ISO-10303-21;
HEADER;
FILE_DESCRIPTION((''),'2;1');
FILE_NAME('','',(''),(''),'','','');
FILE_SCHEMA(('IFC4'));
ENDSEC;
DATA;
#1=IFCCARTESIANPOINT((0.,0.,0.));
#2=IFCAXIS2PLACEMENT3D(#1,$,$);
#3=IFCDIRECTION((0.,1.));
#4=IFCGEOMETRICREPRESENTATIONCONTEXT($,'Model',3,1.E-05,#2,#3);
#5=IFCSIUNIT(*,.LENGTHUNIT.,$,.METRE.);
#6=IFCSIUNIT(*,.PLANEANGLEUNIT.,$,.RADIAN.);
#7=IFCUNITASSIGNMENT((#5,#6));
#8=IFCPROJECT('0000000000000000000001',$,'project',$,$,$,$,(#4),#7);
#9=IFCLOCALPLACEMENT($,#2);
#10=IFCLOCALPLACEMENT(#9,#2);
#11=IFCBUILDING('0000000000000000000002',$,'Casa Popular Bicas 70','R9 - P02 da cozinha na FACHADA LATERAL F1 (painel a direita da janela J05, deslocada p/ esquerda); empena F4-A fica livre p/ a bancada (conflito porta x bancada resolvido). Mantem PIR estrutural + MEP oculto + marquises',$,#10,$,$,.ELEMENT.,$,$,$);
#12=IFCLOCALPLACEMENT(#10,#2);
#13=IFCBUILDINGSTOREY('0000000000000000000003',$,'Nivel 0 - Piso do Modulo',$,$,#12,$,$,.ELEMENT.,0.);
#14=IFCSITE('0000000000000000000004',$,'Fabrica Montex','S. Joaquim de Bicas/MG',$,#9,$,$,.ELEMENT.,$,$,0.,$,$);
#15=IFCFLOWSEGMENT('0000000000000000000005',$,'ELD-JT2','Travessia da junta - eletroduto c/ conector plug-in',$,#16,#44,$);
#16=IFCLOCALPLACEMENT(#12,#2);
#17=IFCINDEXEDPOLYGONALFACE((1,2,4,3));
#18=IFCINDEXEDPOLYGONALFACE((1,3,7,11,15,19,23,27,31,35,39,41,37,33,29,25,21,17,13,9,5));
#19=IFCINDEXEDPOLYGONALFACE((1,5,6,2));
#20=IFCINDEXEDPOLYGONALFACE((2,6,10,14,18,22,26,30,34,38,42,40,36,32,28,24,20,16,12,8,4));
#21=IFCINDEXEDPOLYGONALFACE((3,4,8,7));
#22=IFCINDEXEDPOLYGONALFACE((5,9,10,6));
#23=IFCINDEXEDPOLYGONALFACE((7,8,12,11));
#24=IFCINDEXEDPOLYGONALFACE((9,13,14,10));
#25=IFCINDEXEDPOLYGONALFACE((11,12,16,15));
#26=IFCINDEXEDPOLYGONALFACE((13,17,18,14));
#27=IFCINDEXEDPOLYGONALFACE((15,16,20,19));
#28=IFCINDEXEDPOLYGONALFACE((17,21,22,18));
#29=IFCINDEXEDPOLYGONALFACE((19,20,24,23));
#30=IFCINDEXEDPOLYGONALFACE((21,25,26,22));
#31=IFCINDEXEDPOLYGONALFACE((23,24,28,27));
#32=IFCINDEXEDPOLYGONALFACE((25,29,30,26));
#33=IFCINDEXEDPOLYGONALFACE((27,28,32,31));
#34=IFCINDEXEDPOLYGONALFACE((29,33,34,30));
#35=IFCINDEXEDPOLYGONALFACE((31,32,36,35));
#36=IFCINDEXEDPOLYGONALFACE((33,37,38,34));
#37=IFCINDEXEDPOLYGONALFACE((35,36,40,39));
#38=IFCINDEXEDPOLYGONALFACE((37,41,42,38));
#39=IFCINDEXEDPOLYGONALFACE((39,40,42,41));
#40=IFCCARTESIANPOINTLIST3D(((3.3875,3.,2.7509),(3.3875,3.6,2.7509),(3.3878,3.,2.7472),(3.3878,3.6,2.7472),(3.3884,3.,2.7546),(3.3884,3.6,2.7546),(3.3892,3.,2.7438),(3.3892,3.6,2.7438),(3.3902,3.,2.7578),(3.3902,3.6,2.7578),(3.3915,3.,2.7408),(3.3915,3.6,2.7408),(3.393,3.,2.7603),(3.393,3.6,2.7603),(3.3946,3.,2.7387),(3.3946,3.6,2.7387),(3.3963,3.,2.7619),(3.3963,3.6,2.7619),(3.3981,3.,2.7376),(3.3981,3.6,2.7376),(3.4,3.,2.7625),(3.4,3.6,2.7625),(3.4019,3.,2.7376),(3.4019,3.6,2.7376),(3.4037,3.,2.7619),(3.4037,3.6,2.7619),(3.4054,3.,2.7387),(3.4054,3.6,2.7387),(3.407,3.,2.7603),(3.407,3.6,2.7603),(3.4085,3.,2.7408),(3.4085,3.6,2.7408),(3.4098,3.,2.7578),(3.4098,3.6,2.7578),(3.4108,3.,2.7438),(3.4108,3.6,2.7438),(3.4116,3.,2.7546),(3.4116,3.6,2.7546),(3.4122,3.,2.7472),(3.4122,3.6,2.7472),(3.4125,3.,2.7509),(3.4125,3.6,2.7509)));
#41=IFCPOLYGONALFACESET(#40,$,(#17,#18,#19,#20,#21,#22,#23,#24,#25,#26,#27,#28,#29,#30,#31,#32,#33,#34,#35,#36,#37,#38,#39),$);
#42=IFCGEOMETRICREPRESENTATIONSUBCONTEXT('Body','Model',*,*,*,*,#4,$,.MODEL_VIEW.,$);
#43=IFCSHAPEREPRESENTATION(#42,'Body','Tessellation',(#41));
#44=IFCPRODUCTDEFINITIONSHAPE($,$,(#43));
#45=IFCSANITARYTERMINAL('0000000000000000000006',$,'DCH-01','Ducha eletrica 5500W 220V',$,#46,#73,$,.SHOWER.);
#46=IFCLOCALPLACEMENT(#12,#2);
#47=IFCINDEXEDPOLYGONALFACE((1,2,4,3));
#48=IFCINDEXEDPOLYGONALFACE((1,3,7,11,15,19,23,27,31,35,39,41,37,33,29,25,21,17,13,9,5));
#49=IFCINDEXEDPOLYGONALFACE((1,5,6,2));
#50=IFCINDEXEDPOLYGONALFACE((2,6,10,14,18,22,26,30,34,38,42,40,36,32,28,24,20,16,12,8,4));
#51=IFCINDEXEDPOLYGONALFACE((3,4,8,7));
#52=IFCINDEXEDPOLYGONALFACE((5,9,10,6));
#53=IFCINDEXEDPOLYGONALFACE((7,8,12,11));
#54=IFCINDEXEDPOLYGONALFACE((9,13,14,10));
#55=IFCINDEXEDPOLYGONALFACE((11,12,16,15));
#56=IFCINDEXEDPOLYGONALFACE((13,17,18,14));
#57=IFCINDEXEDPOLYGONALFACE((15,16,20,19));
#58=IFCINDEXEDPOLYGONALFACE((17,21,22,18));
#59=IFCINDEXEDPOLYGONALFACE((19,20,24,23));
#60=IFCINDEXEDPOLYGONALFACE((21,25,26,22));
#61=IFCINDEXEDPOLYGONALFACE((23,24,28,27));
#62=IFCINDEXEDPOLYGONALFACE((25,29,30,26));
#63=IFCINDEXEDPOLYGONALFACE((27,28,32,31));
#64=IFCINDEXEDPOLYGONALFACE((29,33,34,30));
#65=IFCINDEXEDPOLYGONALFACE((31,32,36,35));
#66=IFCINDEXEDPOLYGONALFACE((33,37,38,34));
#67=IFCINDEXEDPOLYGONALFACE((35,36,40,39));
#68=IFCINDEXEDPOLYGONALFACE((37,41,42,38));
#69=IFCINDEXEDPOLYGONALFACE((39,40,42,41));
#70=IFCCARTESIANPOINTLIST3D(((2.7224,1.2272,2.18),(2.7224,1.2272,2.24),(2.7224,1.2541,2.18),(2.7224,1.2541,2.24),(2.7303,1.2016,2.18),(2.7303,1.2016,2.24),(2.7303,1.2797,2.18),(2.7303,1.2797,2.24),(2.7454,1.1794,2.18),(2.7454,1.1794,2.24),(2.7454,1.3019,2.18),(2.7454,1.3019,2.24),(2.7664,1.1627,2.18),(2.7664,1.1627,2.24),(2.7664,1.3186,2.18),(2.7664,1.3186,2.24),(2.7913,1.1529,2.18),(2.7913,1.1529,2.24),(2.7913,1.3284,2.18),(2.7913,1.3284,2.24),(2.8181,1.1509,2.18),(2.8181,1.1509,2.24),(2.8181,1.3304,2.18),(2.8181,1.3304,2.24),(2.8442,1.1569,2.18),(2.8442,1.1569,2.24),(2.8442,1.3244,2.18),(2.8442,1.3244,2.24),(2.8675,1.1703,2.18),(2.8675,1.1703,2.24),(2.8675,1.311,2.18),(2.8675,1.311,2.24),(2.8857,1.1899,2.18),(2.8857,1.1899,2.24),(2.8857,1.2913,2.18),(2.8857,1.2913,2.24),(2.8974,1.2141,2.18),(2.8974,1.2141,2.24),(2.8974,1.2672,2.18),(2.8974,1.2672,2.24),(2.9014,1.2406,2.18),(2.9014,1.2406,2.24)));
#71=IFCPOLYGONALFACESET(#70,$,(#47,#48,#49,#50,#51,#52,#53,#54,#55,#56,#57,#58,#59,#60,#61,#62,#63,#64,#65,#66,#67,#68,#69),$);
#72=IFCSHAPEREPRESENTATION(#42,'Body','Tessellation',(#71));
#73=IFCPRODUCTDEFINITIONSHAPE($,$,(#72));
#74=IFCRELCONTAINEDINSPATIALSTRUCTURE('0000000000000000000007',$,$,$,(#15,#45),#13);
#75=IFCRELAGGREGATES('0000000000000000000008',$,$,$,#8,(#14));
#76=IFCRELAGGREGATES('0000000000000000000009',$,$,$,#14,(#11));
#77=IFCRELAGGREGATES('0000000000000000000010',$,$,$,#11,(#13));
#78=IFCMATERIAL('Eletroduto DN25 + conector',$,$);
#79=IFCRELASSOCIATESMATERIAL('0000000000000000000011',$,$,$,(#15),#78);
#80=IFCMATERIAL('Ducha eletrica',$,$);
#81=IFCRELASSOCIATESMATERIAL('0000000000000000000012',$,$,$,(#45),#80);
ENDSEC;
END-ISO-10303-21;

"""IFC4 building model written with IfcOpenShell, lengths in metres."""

from ifc_helpers import new_model, si_unit, direction, frame, origin, origin_2d, place, context, subcontext, project, spatial, circle, extrude, material, element, save


model = new_model("IFC4")

# Units and contexts
model_context = context("Model", 3, precision=1e-05, world=origin(), true_north=direction((0.0, 1.0)))
body_context = subcontext(model_context, "Body", "Model", "MODEL_VIEW")
ifc_project = project(units=[si_unit("LENGTHUNIT", "METRE"), si_unit("PLANEANGLEUNIT", "RADIAN")], contexts=[model_context])

# Site, building, storey
site_placement = place(None, origin())
site = spatial("IfcSite", under=ifc_project, at=site_placement, Name="Fabrica Montex", Description="S. Joaquim de Bicas/MG", CompositionType="ELEMENT", RefElevation=0.0)
building_placement = place(site_placement, origin())
building = spatial("IfcBuilding", under=site, at=building_placement, Name="Casa Popular Bicas 70", Description="R9 - P02 da cozinha na FACHADA LATERAL F1 (painel a direita da janela J05, deslocada p/ esquerda); empena F4-A fica livre p/ a bancada (conflito porta x bancada resolvido). Mantem PIR estrutural + MEP oculto + marquises", CompositionType="ELEMENT")
storey_placement = place(building_placement, origin())
storey = spatial("IfcBuildingStorey", under=building, at=storey_placement, Name="Nivel 0 - Piso do Modulo", CompositionType="ELEMENT", Elevation=0.0)

# Flow segment
ifc_material_1 = material(Name="Eletroduto DN25 + conector")
for number, where, z_axis, x_axis, name in (
    (1, (3.4, 3.0, 2.75), (0.0, 1.0, 0.0), (0.0, 0.0, 1.0), "ELD-JT2"),
):
    element("IfcFlowSegment", number, at=place(storey_placement, frame(where, z_axis=z_axis, x_axis=x_axis)), inside=storey, material=ifc_material_1, Name=name, Description="Travessia da junta - eletroduto c/ conector plug-in", context=body_context, shape_type="SweptSolid", body=[
        extrude(circle(Radius=0.0125, at=origin_2d()), origin(), (0.0, 0.0, 1.0), 0.6),
    ])

# Sanitary terminal
ifc_material_2 = material(Name="Ducha eletrica")
sanitary_terminal_placement = place(storey_placement, frame((2.8114, 1.2406, 2.18)))
element("IfcSanitaryTerminal", 2, at=sanitary_terminal_placement, inside=storey, material=ifc_material_2, Name="DCH-01", Description="Ducha eletrica 5500W 220V", PredefinedType="SHOWER", context=body_context, shape_type="SweptSolid", body=[
    extrude(circle(Radius=0.09, at=origin_2d()), origin(), (0.0, 0.0, 1.0), 0.06),
])

save(model, "model.ifc")
